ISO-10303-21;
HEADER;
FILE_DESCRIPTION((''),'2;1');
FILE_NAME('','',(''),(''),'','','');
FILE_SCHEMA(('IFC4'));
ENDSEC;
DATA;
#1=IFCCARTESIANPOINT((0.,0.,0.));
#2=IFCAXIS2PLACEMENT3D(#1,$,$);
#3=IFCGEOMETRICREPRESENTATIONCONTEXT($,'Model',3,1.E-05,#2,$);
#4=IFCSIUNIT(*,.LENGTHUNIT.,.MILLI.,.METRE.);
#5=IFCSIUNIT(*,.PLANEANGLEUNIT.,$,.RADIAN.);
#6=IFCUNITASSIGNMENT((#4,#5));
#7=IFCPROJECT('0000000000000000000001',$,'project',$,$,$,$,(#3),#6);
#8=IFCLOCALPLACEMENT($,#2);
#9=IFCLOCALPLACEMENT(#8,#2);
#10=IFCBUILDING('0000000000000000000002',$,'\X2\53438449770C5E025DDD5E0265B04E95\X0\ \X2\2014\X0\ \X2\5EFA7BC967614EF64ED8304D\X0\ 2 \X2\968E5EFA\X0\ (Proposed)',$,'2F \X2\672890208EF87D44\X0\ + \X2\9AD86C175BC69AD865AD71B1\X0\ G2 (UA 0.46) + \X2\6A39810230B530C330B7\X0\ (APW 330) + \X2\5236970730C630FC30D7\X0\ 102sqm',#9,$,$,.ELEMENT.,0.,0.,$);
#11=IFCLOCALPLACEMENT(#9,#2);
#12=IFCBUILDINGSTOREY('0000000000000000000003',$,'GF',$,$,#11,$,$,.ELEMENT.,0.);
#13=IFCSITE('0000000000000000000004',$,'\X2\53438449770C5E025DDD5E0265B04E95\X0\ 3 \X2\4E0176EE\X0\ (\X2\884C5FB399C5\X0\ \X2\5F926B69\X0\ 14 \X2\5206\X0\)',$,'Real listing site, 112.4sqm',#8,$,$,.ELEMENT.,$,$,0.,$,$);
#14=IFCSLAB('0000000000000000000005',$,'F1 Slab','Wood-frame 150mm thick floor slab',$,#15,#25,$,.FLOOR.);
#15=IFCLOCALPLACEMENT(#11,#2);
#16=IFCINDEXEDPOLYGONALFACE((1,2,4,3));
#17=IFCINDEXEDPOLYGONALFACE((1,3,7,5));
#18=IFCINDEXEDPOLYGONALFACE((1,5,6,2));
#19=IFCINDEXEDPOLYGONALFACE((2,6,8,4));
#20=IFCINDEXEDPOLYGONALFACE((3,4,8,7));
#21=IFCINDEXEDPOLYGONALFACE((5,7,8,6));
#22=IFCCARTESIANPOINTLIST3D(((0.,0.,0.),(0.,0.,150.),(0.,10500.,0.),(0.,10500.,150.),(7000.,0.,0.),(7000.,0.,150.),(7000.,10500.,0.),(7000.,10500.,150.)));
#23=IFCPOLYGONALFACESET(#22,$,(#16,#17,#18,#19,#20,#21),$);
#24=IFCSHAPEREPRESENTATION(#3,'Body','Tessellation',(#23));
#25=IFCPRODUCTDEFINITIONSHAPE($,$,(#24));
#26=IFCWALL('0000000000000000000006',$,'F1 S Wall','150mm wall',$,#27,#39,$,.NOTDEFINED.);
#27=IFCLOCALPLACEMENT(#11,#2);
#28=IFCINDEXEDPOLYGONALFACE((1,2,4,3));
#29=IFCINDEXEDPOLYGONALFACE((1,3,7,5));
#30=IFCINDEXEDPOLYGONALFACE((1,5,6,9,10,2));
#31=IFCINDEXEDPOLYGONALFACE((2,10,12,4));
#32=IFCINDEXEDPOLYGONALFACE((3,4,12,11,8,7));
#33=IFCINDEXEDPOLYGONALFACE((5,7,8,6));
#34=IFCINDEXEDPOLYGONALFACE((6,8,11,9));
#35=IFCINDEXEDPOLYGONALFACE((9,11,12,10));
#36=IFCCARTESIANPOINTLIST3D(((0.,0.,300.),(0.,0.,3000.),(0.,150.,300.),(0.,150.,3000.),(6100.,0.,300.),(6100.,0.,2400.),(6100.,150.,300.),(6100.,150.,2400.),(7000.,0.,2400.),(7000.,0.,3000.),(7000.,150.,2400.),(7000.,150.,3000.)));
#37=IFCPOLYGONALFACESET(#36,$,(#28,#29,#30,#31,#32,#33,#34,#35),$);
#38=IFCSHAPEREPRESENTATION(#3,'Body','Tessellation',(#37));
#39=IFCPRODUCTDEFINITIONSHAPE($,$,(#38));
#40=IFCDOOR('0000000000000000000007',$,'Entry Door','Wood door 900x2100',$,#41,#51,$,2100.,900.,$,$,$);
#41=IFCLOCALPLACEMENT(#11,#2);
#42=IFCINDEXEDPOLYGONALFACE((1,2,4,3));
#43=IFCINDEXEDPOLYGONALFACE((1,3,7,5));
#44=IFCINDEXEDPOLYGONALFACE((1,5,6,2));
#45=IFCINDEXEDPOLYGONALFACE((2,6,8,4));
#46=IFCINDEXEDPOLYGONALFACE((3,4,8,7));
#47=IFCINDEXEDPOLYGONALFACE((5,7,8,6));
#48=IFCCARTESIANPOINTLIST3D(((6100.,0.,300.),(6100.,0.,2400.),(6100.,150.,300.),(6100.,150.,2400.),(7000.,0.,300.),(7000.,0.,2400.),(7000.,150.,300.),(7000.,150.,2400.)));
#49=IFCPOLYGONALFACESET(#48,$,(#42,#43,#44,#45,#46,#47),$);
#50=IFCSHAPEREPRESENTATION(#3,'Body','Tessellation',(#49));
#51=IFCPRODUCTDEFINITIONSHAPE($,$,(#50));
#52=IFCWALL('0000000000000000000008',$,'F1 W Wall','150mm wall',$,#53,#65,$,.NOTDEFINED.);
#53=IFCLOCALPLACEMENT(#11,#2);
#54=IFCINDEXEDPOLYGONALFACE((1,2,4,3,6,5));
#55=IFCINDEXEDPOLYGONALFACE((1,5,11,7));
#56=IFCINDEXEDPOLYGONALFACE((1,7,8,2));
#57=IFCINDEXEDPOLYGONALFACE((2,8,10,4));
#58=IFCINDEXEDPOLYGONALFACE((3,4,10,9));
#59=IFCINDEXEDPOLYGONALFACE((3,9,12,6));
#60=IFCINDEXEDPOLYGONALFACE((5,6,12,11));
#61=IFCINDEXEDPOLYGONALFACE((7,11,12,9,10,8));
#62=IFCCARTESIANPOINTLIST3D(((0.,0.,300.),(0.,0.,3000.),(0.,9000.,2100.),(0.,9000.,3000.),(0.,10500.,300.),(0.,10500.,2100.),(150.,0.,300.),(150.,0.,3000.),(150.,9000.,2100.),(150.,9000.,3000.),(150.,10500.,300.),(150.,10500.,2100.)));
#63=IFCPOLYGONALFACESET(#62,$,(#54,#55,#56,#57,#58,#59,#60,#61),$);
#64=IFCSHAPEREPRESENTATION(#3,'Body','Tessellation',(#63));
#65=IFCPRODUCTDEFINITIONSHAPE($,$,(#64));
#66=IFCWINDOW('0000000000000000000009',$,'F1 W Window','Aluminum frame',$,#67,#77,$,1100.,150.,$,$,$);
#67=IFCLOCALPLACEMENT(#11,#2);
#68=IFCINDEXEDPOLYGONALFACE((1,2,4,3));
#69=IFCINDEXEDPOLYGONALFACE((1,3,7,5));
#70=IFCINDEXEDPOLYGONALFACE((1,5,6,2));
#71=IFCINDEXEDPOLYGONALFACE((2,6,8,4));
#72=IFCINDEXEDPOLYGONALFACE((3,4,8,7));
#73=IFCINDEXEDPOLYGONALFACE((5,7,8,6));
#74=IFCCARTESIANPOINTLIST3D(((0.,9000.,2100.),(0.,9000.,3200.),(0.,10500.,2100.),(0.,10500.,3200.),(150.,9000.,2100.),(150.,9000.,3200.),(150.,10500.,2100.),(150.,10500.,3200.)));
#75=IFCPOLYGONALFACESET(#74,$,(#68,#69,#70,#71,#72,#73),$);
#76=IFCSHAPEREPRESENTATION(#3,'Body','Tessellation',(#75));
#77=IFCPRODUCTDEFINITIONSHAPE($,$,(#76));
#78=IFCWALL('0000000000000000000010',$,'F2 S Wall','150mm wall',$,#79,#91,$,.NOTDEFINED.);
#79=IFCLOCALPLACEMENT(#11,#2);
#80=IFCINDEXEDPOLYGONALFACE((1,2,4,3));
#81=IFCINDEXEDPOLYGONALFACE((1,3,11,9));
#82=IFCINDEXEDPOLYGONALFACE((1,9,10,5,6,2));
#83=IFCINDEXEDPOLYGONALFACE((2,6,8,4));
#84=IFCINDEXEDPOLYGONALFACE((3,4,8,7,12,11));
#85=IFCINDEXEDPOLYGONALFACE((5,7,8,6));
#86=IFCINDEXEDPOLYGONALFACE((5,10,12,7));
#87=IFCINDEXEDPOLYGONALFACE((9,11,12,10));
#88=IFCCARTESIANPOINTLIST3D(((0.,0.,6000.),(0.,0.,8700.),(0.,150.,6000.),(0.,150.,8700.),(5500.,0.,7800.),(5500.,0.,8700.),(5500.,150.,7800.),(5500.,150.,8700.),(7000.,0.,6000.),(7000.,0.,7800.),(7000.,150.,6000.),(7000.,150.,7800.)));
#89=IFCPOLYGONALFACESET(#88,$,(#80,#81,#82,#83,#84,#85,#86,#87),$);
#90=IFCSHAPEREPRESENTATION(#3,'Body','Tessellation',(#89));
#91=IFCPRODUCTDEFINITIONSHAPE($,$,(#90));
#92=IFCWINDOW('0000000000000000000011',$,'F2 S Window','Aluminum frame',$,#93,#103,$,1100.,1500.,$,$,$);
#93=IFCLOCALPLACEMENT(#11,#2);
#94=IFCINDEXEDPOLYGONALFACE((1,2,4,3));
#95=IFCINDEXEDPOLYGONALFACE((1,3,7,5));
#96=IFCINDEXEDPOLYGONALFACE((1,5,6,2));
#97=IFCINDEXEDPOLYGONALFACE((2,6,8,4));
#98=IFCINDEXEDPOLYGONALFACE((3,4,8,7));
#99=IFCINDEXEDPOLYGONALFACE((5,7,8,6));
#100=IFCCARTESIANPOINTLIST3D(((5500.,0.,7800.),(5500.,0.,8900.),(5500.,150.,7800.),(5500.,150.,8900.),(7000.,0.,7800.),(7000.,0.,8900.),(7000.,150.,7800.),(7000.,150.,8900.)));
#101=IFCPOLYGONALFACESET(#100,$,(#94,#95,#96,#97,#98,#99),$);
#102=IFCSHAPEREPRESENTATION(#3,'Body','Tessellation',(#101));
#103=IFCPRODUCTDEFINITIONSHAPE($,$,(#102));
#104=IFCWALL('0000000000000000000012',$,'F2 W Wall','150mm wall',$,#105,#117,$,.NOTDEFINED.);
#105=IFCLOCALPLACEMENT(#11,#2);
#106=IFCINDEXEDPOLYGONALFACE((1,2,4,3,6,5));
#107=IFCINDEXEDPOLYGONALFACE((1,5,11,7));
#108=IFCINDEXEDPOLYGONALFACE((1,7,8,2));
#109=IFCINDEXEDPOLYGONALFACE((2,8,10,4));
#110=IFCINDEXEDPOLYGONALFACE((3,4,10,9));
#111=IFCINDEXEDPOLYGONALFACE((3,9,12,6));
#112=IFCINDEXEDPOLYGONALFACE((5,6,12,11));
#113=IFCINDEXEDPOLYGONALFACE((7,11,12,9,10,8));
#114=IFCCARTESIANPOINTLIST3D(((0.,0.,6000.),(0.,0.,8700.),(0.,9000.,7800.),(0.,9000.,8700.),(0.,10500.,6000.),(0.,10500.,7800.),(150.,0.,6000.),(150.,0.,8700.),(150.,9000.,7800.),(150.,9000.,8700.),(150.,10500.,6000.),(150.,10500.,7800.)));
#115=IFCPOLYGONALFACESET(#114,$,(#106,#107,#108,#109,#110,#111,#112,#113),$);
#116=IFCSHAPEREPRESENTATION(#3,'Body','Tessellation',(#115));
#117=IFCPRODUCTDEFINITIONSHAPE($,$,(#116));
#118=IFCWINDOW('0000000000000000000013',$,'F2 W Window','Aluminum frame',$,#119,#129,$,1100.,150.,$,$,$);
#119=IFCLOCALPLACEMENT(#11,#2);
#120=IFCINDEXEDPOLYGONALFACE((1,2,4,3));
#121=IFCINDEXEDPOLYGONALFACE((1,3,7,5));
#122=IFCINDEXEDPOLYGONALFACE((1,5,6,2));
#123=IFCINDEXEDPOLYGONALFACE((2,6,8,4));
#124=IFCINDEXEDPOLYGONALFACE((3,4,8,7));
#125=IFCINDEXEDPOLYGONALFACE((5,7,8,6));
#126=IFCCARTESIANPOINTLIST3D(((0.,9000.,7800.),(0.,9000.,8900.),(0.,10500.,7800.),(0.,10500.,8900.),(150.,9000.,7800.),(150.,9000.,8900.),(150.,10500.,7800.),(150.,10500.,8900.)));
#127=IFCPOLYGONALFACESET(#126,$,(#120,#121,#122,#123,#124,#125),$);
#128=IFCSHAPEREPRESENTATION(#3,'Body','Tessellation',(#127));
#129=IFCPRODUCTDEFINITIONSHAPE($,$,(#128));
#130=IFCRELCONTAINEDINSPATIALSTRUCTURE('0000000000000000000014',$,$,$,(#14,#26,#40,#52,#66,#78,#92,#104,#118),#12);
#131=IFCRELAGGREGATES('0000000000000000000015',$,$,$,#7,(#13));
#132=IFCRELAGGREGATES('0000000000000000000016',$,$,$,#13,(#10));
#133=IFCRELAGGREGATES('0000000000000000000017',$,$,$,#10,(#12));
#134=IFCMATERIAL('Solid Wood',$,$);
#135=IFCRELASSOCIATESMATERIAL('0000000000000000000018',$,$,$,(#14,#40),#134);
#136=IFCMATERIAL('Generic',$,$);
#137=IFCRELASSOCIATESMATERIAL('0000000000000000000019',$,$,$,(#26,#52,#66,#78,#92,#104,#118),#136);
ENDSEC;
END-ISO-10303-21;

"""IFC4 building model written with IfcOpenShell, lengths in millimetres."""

from ifc_helpers import new_model, si_unit, frame, frame_2d, origin, place, context, project, spatial, rectangle, extrude, material, element, fill, save


model = new_model("IFC4")

# Units and contexts
model_context = context("Model", 3, precision=1e-05, world=origin())
ifc_project = project(units=[si_unit("LENGTHUNIT", "METRE", prefix="MILLI"), si_unit("PLANEANGLEUNIT", "RADIAN")], contexts=[model_context])

# Site, building, storey
site_placement = place(None, origin())
site = spatial("IfcSite", under=ifc_project, at=site_placement, Name="千葉県市川市新井 3 丁目 (行徳駅 徒歩 14 分)", ObjectType="Real listing site, 112.4sqm", CompositionType="ELEMENT", RefElevation=0.0)
building_placement = place(site_placement, origin())
building = spatial("IfcBuilding", under=site, at=building_placement, Name="千葉県市川市新井 — 建築条件付き 2 階建 (Proposed)", ObjectType="2F 木造軸組 + 高気密高断熱 G2 (UA 0.46) + 樹脂サッシ (APW 330) + 制震テープ 102sqm", CompositionType="ELEMENT", ElevationOfRefHeight=0.0, ElevationOfTerrain=0.0)
storey_placement = place(building_placement, origin())
storey = spatial("IfcBuildingStorey", under=building, at=storey_placement, Name="GF", CompositionType="ELEMENT", Elevation=0.0)

# Slab
ifc_material_1 = material(Name="Solid Wood")
slab_1_placement = place(storey_placement, origin())
element("IfcSlab", 1, at=slab_1_placement, inside=storey, material=ifc_material_1, Name="F1 Slab", Description="Wood-frame 150mm thick floor slab", PredefinedType="FLOOR", context=model_context, shape_type="SweptSolid", body=[
    extrude(rectangle(XDim=7000.0, YDim=10500.0, at=frame_2d((3500.0, 5250.0))), origin(), (0.0, 0.0, 1.0), 150.0),
])

# Shared definitions
ifc_material_2 = material(Name="Generic")

# Wall, opening, door
wall_1_placement = place(storey_placement, frame((0.0, 0.0, 150.0)))
wall_1 = element("IfcWall", 2, at=wall_1_placement, inside=storey, material=ifc_material_2, Name="F1 S Wall", Description="150mm wall", PredefinedType="NOTDEFINED", context=model_context, shape_type="SweptSolid", body=[
    extrude(rectangle(XDim=7000.0, YDim=150.0, at=frame_2d((3500.0, 75.0))), frame((0.0, 0.0, 150.0)), (0.0, 0.0, 1.0), 2700.0),
])
opening_1_placement = place(storey_placement, frame((3050.0, 0.0, 150.0)))
opening_1 = element("IfcOpeningElement", 3, at=opening_1_placement, cuts=wall_1, PredefinedType="NOTDEFINED", context=model_context, shape_type="SweptSolid", body=[
    extrude(rectangle(XDim=900.0, YDim=150.0, at=frame_2d((450.0, 75.0))), frame((3050.0, 0.0, 150.0)), (0.0, 0.0, 1.0), 2100.0),
])
door_placement = place(storey_placement, frame((3050.0, 0.0, 150.0)))
door = element("IfcDoor", 4, at=door_placement, inside=storey, material=ifc_material_1, Name="Entry Door", Description="Wood door 900x2100", OverallHeight=2100.0, OverallWidth=900.0, context=model_context, shape_type="SweptSolid", body=[
    extrude(rectangle(XDim=900.0, YDim=150.0, at=frame_2d((450.0, 75.0))), frame((3050.0, 0.0, 150.0)), (0.0, 0.0, 1.0), 2100.0),
])
fill(opening_1, door)

# Walls, openings, windows
wall_2_placement = place(storey_placement, frame((0.0, 0.0, 150.0)))
wall_2 = element("IfcWall", 5, at=wall_2_placement, inside=storey, material=ifc_material_2, Name="F1 W Wall", Description="150mm wall", PredefinedType="NOTDEFINED", context=model_context, shape_type="SweptSolid", body=[
    extrude(rectangle(XDim=150.0, YDim=10500.0, at=frame_2d((75.0, 5250.0))), frame((0.0, 0.0, 150.0)), (0.0, 0.0, 1.0), 2700.0),
])
opening_2_placement = place(storey_placement, frame((0.0, 4500.0, 1050.0)))
opening_2 = element("IfcOpeningElement", 6, at=opening_2_placement, cuts=wall_2, PredefinedType="NOTDEFINED", context=model_context, shape_type="SweptSolid", body=[
    extrude(rectangle(XDim=150.0, YDim=1500.0, at=frame_2d((75.0, 750.0))), frame((0.0, 4500.0, 1050.0)), (0.0, 0.0, 1.0), 1100.0),
])
window_1_placement = place(storey_placement, frame((0.0, 4500.0, 1050.0)))
window_1 = element("IfcWindow", 7, at=window_1_placement, inside=storey, material=ifc_material_2, Name="F1 W Window", Description="Aluminum frame", OverallHeight=1100.0, OverallWidth=150.0, context=model_context, shape_type="SweptSolid", body=[
    extrude(rectangle(XDim=150.0, YDim=1500.0, at=frame_2d((75.0, 750.0))), frame((0.0, 4500.0, 1050.0)), (0.0, 0.0, 1.0), 1100.0),
])
fill(opening_2, window_1)
wall_3_placement = place(storey_placement, frame((0.0, 0.0, 3000.0)))
wall_3 = element("IfcWall", 8, at=wall_3_placement, inside=storey, material=ifc_material_2, Name="F2 S Wall", Description="150mm wall", PredefinedType="NOTDEFINED", context=model_context, shape_type="SweptSolid", body=[
    extrude(rectangle(XDim=7000.0, YDim=150.0, at=frame_2d((3500.0, 75.0))), frame((0.0, 0.0, 3000.0)), (0.0, 0.0, 1.0), 2700.0),
])
opening_3_placement = place(storey_placement, frame((2750.0, 0.0, 3900.0)))
opening_3 = element("IfcOpeningElement", 9, at=opening_3_placement, cuts=wall_3, PredefinedType="NOTDEFINED", context=model_context, shape_type="SweptSolid", body=[
    extrude(rectangle(XDim=1500.0, YDim=150.0, at=frame_2d((750.0, 75.0))), frame((2750.0, 0.0, 3900.0)), (0.0, 0.0, 1.0), 1100.0),
])
window_2_placement = place(storey_placement, frame((2750.0, 0.0, 3900.0)))
window_2 = element("IfcWindow", 10, at=window_2_placement, inside=storey, material=ifc_material_2, Name="F2 S Window", Description="Aluminum frame", OverallHeight=1100.0, OverallWidth=1500.0, context=model_context, shape_type="SweptSolid", body=[
    extrude(rectangle(XDim=1500.0, YDim=150.0, at=frame_2d((750.0, 75.0))), frame((2750.0, 0.0, 3900.0)), (0.0, 0.0, 1.0), 1100.0),
])
fill(opening_3, window_2)
wall_4_placement = place(storey_placement, frame((0.0, 0.0, 3000.0)))
wall_4 = element("IfcWall", 11, at=wall_4_placement, inside=storey, material=ifc_material_2, Name="F2 W Wall", Description="150mm wall", PredefinedType="NOTDEFINED", context=model_context, shape_type="SweptSolid", body=[
    extrude(rectangle(XDim=150.0, YDim=10500.0, at=frame_2d((75.0, 5250.0))), frame((0.0, 0.0, 3000.0)), (0.0, 0.0, 1.0), 2700.0),
])
opening_4_placement = place(storey_placement, frame((0.0, 4500.0, 3900.0)))
opening_4 = element("IfcOpeningElement", 12, at=opening_4_placement, cuts=wall_4, PredefinedType="NOTDEFINED", context=model_context, shape_type="SweptSolid", body=[
    extrude(rectangle(XDim=150.0, YDim=1500.0, at=frame_2d((75.0, 750.0))), frame((0.0, 4500.0, 3900.0)), (0.0, 0.0, 1.0), 1100.0),
])
window_3_placement = place(storey_placement, frame((0.0, 4500.0, 3900.0)))
window_3 = element("IfcWindow", 13, at=window_3_placement, inside=storey, material=ifc_material_2, Name="F2 W Window", Description="Aluminum frame", OverallHeight=1100.0, OverallWidth=150.0, context=model_context, shape_type="SweptSolid", body=[
    extrude(rectangle(XDim=150.0, YDim=1500.0, at=frame_2d((75.0, 750.0))), frame((0.0, 4500.0, 3900.0)), (0.0, 0.0, 1.0), 1100.0),
])
fill(opening_4, window_3)

save(model, "model.ifc")
